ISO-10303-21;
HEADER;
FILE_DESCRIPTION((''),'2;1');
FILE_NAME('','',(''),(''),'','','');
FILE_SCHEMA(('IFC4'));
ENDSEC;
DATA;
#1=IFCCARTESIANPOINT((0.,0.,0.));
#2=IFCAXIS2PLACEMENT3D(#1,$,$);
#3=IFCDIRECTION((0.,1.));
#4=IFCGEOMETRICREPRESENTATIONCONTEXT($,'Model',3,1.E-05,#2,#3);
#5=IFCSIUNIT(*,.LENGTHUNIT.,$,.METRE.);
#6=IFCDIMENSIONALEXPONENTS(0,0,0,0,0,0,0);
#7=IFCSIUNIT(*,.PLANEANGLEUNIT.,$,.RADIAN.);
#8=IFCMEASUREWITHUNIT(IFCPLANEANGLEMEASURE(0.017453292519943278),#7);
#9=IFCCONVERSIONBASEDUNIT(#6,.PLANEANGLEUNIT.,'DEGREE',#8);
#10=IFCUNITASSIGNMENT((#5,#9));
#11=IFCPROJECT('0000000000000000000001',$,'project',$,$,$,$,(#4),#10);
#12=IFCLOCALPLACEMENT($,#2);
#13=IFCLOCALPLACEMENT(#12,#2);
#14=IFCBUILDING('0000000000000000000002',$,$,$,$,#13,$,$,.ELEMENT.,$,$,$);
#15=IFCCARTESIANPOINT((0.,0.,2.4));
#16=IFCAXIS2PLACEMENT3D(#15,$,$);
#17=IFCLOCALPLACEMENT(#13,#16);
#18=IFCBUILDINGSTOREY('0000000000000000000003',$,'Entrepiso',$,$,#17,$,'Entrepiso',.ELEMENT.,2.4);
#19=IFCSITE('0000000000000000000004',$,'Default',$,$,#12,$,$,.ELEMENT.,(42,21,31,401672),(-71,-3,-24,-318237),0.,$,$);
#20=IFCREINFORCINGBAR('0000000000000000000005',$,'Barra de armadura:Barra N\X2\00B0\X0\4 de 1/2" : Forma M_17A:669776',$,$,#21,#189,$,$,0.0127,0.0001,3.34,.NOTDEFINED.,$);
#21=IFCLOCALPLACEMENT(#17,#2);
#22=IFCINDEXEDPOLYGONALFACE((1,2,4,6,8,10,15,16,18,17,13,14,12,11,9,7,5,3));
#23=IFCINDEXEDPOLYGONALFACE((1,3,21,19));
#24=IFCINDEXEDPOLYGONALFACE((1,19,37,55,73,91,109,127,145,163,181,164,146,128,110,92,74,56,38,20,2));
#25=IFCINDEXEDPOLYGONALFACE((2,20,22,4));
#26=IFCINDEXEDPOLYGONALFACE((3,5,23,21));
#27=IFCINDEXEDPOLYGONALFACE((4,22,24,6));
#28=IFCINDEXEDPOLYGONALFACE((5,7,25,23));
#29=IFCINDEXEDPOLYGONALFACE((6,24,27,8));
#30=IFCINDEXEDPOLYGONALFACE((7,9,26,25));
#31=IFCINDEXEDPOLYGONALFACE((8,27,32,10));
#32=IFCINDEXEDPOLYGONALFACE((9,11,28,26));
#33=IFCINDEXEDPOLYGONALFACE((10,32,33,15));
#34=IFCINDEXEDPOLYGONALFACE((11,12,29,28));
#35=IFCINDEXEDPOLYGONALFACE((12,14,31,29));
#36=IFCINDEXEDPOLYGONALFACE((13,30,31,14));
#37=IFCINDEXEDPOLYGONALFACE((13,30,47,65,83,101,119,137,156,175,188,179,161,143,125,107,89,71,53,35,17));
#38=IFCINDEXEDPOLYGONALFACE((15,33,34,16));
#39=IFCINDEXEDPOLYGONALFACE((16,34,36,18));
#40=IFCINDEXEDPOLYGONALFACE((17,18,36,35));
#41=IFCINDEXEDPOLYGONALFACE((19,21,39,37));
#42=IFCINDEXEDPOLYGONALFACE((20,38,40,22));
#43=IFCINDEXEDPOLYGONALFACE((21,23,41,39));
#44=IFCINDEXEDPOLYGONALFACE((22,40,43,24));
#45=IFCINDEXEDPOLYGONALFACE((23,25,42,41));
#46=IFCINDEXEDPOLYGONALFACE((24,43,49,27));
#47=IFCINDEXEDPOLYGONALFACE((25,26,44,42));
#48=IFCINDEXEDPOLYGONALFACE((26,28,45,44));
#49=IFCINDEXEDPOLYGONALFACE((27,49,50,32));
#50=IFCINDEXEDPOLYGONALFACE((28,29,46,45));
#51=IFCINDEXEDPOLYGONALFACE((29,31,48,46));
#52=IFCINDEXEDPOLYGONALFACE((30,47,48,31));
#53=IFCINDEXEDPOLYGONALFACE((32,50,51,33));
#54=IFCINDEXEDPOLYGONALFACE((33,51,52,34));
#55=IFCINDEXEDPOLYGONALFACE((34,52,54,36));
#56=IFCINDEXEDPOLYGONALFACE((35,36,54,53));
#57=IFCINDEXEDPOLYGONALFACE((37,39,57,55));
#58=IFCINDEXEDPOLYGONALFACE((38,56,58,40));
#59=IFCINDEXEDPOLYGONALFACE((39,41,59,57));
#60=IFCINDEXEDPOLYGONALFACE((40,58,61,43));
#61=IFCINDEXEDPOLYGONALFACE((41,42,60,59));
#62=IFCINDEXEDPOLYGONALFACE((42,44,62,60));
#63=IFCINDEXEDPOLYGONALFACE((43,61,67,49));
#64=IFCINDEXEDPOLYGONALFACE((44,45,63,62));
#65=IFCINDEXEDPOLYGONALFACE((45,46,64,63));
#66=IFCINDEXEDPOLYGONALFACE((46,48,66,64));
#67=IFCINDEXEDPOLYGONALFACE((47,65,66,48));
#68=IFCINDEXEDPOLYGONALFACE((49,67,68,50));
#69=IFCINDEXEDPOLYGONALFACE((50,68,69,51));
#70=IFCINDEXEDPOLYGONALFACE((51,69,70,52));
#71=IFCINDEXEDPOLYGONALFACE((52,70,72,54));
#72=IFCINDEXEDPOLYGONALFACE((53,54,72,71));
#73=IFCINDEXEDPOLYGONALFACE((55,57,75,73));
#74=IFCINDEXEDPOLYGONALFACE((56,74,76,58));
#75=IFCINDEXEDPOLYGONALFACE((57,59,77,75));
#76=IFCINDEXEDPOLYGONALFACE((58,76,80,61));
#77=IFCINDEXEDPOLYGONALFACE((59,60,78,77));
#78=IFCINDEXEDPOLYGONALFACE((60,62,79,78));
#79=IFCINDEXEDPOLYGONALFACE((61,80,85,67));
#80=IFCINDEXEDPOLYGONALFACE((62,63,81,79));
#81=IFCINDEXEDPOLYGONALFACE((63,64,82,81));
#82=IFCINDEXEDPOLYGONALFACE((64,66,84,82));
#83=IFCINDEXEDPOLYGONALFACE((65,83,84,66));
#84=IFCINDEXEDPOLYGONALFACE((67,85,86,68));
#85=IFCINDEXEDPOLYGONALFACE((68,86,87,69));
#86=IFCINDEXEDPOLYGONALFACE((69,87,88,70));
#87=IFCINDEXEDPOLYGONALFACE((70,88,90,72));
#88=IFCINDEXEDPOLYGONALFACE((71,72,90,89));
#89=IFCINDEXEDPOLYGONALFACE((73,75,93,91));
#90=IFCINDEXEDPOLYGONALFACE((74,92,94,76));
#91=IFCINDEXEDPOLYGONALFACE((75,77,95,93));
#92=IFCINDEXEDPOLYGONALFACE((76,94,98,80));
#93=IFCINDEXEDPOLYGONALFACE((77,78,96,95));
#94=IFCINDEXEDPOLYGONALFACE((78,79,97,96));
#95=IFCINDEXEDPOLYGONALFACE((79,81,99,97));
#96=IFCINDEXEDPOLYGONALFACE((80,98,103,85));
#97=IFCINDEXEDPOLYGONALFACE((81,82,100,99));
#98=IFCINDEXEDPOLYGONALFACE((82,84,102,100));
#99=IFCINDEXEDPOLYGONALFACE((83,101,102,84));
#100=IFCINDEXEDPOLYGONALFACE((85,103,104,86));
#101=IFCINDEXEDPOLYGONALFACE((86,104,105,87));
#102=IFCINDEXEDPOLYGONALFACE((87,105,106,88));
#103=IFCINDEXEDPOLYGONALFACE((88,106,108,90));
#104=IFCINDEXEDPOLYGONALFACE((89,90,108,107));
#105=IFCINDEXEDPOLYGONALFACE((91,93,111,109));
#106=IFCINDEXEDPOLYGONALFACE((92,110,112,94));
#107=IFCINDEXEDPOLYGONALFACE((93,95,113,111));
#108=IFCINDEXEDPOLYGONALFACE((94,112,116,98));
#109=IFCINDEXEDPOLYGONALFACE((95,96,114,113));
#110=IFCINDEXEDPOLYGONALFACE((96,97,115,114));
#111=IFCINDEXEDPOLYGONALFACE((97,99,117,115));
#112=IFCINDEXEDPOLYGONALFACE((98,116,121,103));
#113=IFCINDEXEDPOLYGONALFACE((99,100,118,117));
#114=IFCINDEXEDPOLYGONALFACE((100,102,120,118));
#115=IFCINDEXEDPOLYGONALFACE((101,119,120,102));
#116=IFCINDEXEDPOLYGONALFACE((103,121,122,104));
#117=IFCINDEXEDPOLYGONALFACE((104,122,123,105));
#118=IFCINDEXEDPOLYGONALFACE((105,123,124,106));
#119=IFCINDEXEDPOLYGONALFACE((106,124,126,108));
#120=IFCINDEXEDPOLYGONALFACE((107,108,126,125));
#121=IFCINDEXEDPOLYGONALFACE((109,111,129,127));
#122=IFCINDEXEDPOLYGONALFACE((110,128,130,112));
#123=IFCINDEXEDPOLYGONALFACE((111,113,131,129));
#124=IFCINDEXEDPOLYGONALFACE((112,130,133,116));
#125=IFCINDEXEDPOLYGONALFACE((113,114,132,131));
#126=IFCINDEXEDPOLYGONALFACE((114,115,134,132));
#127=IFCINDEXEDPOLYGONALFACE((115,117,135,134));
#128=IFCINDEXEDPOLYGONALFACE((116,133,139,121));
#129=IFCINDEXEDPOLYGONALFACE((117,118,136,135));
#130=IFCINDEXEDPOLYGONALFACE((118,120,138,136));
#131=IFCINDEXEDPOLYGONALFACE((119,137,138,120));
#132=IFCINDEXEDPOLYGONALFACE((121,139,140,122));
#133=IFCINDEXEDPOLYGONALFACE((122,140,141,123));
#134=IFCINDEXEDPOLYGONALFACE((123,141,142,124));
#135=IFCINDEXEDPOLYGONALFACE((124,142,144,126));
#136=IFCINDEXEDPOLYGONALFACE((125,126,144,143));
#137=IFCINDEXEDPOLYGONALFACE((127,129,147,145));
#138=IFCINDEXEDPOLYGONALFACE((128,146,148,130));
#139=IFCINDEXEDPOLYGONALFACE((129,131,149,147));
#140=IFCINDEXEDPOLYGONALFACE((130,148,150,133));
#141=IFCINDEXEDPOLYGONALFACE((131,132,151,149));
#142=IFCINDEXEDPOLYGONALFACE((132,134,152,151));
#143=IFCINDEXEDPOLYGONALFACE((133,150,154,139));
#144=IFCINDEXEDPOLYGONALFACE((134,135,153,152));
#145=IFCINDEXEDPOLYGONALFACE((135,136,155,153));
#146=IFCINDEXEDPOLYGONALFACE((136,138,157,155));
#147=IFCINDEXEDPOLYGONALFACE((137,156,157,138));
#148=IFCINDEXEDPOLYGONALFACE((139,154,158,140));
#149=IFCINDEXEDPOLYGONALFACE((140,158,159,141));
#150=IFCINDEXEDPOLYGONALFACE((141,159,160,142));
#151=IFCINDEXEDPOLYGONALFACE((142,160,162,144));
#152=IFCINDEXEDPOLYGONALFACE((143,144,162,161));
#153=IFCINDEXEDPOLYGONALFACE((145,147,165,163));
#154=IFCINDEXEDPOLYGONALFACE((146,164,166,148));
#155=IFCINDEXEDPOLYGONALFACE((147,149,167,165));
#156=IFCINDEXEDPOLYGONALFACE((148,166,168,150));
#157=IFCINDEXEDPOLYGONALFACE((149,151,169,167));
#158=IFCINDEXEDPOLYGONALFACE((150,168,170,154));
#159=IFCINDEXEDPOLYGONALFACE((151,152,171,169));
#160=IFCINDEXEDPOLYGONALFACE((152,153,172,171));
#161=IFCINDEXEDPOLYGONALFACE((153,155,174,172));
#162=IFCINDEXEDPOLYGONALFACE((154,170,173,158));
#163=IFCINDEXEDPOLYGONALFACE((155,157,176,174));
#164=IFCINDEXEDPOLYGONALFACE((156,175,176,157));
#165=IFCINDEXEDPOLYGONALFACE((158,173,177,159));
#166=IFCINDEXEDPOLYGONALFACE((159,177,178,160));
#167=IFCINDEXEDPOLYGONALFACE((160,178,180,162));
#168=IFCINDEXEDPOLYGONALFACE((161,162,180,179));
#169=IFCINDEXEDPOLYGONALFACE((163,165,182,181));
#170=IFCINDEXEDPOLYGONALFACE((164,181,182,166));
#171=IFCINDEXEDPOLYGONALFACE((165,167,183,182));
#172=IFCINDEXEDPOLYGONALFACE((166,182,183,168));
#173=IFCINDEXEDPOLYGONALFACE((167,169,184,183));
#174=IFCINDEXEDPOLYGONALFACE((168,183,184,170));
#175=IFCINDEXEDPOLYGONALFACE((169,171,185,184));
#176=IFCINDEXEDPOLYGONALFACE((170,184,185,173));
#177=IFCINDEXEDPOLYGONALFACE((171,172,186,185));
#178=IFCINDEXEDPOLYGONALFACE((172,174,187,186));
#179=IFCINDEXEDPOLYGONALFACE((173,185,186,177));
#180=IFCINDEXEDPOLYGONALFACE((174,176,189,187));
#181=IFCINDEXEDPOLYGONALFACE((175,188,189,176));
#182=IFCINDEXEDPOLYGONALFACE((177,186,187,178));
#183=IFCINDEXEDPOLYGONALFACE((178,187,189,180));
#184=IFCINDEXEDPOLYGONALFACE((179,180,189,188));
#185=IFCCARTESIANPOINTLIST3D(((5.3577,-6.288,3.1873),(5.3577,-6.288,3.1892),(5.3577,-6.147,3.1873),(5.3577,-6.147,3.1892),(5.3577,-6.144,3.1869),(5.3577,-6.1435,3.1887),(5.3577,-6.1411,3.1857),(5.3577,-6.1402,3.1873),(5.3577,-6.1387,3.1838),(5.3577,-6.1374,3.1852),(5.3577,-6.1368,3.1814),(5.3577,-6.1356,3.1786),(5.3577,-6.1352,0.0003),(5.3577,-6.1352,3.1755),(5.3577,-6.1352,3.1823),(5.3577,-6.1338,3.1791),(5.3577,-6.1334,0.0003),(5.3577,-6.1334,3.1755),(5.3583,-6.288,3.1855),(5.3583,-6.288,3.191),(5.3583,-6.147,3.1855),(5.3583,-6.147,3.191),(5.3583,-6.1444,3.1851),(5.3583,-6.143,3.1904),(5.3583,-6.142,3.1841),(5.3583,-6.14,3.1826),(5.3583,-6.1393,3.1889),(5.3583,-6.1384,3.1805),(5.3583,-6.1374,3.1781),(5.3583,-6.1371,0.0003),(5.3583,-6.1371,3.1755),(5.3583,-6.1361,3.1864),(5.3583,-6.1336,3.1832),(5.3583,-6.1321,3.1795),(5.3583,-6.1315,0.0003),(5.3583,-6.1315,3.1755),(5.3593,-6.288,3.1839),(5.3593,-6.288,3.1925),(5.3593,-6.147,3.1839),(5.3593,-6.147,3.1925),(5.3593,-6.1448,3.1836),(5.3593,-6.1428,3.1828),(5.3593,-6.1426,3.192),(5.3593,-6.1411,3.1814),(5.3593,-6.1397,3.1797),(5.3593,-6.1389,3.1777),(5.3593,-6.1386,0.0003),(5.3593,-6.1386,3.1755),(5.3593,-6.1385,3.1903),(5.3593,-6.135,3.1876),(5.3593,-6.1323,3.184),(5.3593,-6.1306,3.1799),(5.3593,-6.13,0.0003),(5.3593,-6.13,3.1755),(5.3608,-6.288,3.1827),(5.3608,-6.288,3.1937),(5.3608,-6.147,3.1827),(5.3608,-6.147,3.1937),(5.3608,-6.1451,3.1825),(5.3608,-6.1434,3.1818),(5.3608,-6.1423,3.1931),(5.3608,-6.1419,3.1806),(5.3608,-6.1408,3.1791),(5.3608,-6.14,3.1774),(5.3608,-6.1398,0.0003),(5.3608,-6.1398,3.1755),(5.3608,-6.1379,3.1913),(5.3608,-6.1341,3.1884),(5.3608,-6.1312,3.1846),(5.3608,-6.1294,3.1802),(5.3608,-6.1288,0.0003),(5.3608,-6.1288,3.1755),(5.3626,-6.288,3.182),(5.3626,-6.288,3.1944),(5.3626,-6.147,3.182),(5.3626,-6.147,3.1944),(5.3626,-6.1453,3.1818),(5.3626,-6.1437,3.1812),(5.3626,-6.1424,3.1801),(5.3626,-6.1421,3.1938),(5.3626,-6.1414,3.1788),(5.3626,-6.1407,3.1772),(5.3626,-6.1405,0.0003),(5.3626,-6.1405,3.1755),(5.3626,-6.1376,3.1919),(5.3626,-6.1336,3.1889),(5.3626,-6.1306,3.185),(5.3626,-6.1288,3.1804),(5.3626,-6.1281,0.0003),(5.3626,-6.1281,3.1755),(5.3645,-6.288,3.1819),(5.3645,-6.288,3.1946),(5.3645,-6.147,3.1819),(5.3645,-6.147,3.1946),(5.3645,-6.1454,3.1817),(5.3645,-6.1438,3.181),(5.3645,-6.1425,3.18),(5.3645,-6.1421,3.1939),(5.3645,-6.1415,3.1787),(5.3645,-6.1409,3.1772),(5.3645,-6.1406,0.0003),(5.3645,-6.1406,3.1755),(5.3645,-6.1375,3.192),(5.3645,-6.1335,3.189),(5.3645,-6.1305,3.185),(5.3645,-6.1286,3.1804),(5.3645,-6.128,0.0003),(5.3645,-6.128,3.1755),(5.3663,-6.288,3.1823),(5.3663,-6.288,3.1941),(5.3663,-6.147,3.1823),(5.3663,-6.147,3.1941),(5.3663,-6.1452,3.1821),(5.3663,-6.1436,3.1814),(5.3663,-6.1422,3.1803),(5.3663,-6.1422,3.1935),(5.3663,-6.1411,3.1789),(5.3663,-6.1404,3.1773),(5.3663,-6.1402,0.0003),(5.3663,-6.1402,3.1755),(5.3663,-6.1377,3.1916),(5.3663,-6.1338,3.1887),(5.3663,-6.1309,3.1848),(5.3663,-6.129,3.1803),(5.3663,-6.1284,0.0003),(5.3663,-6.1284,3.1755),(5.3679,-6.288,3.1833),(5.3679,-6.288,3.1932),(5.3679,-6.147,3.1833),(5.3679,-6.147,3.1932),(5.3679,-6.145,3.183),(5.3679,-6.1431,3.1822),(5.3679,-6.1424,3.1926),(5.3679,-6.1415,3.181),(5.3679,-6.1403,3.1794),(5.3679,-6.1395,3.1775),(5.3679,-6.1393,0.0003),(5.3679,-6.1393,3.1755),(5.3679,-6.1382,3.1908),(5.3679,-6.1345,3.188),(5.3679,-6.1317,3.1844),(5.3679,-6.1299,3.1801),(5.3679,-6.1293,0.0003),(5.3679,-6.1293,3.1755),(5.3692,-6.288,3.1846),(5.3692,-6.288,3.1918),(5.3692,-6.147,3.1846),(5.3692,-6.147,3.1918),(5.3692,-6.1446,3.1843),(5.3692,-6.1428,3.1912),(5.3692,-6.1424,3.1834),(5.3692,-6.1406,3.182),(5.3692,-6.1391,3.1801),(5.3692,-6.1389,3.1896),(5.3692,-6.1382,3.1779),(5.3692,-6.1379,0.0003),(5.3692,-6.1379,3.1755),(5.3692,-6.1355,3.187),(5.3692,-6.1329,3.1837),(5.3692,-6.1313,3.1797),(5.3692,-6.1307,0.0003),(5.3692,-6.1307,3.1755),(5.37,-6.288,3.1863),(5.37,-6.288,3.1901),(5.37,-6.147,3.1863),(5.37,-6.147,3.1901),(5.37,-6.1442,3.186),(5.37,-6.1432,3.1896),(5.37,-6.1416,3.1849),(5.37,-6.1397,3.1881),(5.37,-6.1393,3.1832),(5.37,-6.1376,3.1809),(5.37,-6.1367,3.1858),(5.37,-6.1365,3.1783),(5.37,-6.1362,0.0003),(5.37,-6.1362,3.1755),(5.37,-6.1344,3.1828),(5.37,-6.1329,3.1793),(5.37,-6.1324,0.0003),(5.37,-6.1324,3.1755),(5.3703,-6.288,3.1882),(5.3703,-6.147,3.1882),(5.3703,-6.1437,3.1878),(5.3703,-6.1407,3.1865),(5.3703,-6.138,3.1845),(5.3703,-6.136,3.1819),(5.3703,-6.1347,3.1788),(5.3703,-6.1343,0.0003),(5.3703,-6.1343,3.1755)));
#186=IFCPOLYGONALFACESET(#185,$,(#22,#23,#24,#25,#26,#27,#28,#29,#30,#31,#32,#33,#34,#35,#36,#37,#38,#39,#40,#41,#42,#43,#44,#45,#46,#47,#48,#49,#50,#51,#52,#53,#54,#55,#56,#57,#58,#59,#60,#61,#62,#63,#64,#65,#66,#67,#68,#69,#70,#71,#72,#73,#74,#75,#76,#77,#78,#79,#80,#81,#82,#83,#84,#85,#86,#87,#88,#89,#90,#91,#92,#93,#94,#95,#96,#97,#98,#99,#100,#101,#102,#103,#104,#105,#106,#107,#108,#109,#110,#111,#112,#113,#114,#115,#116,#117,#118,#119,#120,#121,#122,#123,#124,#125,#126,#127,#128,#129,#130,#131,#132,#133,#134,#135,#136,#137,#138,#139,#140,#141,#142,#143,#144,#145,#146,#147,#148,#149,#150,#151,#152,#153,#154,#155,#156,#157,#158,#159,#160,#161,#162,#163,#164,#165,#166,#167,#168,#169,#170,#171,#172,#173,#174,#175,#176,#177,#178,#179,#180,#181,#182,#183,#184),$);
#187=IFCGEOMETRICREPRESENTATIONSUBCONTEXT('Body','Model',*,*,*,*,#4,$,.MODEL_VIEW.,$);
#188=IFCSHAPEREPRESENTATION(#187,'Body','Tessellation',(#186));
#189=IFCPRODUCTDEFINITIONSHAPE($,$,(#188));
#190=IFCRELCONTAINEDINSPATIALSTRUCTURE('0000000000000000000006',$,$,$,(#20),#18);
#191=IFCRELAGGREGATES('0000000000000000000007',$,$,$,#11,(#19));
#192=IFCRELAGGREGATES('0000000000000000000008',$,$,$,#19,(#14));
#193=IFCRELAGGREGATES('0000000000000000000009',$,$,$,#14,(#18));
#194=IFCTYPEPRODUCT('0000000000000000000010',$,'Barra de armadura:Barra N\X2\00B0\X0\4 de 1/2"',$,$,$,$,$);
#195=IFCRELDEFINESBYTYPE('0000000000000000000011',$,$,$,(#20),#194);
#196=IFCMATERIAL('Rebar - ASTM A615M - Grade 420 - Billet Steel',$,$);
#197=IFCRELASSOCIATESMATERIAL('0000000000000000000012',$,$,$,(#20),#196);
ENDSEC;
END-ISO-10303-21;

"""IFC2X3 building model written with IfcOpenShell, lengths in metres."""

from ifc_helpers import new_model, entity, si_unit, converted_unit, direction, frame, origin, place, context, subcontext, project, spatial, material, type_object, element, save


model = new_model("IFC2X3")

# Units and contexts
model_context = context("Model", 3, precision=1e-05, world=origin(), true_north=direction((0.0, 1.0)))
body_context = subcontext(model_context, "Body", "Model", "MODEL_VIEW")
ifc_project = project(units=[si_unit("LENGTHUNIT", "METRE"), converted_unit("PLANEANGLEUNIT", "DEGREE", entity("IfcPlaneAngleMeasure", 0.017453292519943278), si_unit("PLANEANGLEUNIT", "RADIAN"), dimensions=[0, 0, 0, 0, 0, 0, 0])], contexts=[model_context])

# Site, building, storey
site_placement = place(None, origin())
site = spatial("IfcSite", under=ifc_project, at=site_placement, Name="Default", CompositionType="ELEMENT", RefLatitude=(42, 21, 31, 401672), RefLongitude=(-71, -3, -24, -318237), RefElevation=0.0)
building_placement = place(site_placement, origin())
building = spatial("IfcBuilding", under=site, at=building_placement, CompositionType="ELEMENT")
storey_placement = place(building_placement, frame((0.0, 0.0, 2.4)))
storey = spatial("IfcBuildingStorey", under=building, at=storey_placement, Name="Entrepiso", LongName="Entrepiso", CompositionType="ELEMENT", Elevation=2.4)

# Reinforcing bar
ifc_material = material(Name="Rebar - ASTM A615M - Grade 420 - Billet Steel")
type_product_1 = type_object("IfcTypeProduct", Name="Barra de armadura:Barra N°4 de 1/2\"")
reinforcing_bar_1_placement = place(storey_placement, origin())
element("IfcReinforcingBar", 1, at=reinforcing_bar_1_placement, inside=storey, type_object=type_product_1, material=ifc_material, Name="Barra de armadura:Barra N°4 de 1/2\" : Forma M_17A:669776", BarLength=3.34, BarRole="NOTDEFINED", CrossSectionArea=0.0001, NominalDiameter=0.0127, context=body_context, shape_type="AdvancedSweptSolid", body=[
    entity("IfcSweptDiskSolid", entity("IfcCompositeCurve", [entity("IfcCompositeCurveSegment", "CONTINUOUS", True, entity("IfcPolyline", [entity("IfcCartesianPoint", [5.364, -6.1343, 0.0003]), entity("IfcCartesianPoint", [5.364, -6.1343, 3.1755])])), entity("IfcCompositeCurveSegment", "CONTINUOUS", True, entity("IfcTrimmedCurve", entity("IfcCircle", entity("IfcAxis2Placement3D", entity("IfcCartesianPoint", [5.364, -6.147, 3.1755]), entity("IfcDirection", [1.0, 0.0, 0.0]), entity("IfcDirection", [0.0, 0.0, 1.0])), 0.0127), [entity("IfcParameterValue", 270.0)], [entity("IfcParameterValue", 360.0)], True, "PARAMETER")), entity("IfcCompositeCurveSegment", "CONTINUOUS", True, entity("IfcPolyline", [entity("IfcCartesianPoint", [5.364, -6.147, 3.1882]), entity("IfcCartesianPoint", [5.364, -6.288, 3.1882])]))], False), 0.0063, None, 0.0, 92.0),
])

save(model, "model.ifc")
